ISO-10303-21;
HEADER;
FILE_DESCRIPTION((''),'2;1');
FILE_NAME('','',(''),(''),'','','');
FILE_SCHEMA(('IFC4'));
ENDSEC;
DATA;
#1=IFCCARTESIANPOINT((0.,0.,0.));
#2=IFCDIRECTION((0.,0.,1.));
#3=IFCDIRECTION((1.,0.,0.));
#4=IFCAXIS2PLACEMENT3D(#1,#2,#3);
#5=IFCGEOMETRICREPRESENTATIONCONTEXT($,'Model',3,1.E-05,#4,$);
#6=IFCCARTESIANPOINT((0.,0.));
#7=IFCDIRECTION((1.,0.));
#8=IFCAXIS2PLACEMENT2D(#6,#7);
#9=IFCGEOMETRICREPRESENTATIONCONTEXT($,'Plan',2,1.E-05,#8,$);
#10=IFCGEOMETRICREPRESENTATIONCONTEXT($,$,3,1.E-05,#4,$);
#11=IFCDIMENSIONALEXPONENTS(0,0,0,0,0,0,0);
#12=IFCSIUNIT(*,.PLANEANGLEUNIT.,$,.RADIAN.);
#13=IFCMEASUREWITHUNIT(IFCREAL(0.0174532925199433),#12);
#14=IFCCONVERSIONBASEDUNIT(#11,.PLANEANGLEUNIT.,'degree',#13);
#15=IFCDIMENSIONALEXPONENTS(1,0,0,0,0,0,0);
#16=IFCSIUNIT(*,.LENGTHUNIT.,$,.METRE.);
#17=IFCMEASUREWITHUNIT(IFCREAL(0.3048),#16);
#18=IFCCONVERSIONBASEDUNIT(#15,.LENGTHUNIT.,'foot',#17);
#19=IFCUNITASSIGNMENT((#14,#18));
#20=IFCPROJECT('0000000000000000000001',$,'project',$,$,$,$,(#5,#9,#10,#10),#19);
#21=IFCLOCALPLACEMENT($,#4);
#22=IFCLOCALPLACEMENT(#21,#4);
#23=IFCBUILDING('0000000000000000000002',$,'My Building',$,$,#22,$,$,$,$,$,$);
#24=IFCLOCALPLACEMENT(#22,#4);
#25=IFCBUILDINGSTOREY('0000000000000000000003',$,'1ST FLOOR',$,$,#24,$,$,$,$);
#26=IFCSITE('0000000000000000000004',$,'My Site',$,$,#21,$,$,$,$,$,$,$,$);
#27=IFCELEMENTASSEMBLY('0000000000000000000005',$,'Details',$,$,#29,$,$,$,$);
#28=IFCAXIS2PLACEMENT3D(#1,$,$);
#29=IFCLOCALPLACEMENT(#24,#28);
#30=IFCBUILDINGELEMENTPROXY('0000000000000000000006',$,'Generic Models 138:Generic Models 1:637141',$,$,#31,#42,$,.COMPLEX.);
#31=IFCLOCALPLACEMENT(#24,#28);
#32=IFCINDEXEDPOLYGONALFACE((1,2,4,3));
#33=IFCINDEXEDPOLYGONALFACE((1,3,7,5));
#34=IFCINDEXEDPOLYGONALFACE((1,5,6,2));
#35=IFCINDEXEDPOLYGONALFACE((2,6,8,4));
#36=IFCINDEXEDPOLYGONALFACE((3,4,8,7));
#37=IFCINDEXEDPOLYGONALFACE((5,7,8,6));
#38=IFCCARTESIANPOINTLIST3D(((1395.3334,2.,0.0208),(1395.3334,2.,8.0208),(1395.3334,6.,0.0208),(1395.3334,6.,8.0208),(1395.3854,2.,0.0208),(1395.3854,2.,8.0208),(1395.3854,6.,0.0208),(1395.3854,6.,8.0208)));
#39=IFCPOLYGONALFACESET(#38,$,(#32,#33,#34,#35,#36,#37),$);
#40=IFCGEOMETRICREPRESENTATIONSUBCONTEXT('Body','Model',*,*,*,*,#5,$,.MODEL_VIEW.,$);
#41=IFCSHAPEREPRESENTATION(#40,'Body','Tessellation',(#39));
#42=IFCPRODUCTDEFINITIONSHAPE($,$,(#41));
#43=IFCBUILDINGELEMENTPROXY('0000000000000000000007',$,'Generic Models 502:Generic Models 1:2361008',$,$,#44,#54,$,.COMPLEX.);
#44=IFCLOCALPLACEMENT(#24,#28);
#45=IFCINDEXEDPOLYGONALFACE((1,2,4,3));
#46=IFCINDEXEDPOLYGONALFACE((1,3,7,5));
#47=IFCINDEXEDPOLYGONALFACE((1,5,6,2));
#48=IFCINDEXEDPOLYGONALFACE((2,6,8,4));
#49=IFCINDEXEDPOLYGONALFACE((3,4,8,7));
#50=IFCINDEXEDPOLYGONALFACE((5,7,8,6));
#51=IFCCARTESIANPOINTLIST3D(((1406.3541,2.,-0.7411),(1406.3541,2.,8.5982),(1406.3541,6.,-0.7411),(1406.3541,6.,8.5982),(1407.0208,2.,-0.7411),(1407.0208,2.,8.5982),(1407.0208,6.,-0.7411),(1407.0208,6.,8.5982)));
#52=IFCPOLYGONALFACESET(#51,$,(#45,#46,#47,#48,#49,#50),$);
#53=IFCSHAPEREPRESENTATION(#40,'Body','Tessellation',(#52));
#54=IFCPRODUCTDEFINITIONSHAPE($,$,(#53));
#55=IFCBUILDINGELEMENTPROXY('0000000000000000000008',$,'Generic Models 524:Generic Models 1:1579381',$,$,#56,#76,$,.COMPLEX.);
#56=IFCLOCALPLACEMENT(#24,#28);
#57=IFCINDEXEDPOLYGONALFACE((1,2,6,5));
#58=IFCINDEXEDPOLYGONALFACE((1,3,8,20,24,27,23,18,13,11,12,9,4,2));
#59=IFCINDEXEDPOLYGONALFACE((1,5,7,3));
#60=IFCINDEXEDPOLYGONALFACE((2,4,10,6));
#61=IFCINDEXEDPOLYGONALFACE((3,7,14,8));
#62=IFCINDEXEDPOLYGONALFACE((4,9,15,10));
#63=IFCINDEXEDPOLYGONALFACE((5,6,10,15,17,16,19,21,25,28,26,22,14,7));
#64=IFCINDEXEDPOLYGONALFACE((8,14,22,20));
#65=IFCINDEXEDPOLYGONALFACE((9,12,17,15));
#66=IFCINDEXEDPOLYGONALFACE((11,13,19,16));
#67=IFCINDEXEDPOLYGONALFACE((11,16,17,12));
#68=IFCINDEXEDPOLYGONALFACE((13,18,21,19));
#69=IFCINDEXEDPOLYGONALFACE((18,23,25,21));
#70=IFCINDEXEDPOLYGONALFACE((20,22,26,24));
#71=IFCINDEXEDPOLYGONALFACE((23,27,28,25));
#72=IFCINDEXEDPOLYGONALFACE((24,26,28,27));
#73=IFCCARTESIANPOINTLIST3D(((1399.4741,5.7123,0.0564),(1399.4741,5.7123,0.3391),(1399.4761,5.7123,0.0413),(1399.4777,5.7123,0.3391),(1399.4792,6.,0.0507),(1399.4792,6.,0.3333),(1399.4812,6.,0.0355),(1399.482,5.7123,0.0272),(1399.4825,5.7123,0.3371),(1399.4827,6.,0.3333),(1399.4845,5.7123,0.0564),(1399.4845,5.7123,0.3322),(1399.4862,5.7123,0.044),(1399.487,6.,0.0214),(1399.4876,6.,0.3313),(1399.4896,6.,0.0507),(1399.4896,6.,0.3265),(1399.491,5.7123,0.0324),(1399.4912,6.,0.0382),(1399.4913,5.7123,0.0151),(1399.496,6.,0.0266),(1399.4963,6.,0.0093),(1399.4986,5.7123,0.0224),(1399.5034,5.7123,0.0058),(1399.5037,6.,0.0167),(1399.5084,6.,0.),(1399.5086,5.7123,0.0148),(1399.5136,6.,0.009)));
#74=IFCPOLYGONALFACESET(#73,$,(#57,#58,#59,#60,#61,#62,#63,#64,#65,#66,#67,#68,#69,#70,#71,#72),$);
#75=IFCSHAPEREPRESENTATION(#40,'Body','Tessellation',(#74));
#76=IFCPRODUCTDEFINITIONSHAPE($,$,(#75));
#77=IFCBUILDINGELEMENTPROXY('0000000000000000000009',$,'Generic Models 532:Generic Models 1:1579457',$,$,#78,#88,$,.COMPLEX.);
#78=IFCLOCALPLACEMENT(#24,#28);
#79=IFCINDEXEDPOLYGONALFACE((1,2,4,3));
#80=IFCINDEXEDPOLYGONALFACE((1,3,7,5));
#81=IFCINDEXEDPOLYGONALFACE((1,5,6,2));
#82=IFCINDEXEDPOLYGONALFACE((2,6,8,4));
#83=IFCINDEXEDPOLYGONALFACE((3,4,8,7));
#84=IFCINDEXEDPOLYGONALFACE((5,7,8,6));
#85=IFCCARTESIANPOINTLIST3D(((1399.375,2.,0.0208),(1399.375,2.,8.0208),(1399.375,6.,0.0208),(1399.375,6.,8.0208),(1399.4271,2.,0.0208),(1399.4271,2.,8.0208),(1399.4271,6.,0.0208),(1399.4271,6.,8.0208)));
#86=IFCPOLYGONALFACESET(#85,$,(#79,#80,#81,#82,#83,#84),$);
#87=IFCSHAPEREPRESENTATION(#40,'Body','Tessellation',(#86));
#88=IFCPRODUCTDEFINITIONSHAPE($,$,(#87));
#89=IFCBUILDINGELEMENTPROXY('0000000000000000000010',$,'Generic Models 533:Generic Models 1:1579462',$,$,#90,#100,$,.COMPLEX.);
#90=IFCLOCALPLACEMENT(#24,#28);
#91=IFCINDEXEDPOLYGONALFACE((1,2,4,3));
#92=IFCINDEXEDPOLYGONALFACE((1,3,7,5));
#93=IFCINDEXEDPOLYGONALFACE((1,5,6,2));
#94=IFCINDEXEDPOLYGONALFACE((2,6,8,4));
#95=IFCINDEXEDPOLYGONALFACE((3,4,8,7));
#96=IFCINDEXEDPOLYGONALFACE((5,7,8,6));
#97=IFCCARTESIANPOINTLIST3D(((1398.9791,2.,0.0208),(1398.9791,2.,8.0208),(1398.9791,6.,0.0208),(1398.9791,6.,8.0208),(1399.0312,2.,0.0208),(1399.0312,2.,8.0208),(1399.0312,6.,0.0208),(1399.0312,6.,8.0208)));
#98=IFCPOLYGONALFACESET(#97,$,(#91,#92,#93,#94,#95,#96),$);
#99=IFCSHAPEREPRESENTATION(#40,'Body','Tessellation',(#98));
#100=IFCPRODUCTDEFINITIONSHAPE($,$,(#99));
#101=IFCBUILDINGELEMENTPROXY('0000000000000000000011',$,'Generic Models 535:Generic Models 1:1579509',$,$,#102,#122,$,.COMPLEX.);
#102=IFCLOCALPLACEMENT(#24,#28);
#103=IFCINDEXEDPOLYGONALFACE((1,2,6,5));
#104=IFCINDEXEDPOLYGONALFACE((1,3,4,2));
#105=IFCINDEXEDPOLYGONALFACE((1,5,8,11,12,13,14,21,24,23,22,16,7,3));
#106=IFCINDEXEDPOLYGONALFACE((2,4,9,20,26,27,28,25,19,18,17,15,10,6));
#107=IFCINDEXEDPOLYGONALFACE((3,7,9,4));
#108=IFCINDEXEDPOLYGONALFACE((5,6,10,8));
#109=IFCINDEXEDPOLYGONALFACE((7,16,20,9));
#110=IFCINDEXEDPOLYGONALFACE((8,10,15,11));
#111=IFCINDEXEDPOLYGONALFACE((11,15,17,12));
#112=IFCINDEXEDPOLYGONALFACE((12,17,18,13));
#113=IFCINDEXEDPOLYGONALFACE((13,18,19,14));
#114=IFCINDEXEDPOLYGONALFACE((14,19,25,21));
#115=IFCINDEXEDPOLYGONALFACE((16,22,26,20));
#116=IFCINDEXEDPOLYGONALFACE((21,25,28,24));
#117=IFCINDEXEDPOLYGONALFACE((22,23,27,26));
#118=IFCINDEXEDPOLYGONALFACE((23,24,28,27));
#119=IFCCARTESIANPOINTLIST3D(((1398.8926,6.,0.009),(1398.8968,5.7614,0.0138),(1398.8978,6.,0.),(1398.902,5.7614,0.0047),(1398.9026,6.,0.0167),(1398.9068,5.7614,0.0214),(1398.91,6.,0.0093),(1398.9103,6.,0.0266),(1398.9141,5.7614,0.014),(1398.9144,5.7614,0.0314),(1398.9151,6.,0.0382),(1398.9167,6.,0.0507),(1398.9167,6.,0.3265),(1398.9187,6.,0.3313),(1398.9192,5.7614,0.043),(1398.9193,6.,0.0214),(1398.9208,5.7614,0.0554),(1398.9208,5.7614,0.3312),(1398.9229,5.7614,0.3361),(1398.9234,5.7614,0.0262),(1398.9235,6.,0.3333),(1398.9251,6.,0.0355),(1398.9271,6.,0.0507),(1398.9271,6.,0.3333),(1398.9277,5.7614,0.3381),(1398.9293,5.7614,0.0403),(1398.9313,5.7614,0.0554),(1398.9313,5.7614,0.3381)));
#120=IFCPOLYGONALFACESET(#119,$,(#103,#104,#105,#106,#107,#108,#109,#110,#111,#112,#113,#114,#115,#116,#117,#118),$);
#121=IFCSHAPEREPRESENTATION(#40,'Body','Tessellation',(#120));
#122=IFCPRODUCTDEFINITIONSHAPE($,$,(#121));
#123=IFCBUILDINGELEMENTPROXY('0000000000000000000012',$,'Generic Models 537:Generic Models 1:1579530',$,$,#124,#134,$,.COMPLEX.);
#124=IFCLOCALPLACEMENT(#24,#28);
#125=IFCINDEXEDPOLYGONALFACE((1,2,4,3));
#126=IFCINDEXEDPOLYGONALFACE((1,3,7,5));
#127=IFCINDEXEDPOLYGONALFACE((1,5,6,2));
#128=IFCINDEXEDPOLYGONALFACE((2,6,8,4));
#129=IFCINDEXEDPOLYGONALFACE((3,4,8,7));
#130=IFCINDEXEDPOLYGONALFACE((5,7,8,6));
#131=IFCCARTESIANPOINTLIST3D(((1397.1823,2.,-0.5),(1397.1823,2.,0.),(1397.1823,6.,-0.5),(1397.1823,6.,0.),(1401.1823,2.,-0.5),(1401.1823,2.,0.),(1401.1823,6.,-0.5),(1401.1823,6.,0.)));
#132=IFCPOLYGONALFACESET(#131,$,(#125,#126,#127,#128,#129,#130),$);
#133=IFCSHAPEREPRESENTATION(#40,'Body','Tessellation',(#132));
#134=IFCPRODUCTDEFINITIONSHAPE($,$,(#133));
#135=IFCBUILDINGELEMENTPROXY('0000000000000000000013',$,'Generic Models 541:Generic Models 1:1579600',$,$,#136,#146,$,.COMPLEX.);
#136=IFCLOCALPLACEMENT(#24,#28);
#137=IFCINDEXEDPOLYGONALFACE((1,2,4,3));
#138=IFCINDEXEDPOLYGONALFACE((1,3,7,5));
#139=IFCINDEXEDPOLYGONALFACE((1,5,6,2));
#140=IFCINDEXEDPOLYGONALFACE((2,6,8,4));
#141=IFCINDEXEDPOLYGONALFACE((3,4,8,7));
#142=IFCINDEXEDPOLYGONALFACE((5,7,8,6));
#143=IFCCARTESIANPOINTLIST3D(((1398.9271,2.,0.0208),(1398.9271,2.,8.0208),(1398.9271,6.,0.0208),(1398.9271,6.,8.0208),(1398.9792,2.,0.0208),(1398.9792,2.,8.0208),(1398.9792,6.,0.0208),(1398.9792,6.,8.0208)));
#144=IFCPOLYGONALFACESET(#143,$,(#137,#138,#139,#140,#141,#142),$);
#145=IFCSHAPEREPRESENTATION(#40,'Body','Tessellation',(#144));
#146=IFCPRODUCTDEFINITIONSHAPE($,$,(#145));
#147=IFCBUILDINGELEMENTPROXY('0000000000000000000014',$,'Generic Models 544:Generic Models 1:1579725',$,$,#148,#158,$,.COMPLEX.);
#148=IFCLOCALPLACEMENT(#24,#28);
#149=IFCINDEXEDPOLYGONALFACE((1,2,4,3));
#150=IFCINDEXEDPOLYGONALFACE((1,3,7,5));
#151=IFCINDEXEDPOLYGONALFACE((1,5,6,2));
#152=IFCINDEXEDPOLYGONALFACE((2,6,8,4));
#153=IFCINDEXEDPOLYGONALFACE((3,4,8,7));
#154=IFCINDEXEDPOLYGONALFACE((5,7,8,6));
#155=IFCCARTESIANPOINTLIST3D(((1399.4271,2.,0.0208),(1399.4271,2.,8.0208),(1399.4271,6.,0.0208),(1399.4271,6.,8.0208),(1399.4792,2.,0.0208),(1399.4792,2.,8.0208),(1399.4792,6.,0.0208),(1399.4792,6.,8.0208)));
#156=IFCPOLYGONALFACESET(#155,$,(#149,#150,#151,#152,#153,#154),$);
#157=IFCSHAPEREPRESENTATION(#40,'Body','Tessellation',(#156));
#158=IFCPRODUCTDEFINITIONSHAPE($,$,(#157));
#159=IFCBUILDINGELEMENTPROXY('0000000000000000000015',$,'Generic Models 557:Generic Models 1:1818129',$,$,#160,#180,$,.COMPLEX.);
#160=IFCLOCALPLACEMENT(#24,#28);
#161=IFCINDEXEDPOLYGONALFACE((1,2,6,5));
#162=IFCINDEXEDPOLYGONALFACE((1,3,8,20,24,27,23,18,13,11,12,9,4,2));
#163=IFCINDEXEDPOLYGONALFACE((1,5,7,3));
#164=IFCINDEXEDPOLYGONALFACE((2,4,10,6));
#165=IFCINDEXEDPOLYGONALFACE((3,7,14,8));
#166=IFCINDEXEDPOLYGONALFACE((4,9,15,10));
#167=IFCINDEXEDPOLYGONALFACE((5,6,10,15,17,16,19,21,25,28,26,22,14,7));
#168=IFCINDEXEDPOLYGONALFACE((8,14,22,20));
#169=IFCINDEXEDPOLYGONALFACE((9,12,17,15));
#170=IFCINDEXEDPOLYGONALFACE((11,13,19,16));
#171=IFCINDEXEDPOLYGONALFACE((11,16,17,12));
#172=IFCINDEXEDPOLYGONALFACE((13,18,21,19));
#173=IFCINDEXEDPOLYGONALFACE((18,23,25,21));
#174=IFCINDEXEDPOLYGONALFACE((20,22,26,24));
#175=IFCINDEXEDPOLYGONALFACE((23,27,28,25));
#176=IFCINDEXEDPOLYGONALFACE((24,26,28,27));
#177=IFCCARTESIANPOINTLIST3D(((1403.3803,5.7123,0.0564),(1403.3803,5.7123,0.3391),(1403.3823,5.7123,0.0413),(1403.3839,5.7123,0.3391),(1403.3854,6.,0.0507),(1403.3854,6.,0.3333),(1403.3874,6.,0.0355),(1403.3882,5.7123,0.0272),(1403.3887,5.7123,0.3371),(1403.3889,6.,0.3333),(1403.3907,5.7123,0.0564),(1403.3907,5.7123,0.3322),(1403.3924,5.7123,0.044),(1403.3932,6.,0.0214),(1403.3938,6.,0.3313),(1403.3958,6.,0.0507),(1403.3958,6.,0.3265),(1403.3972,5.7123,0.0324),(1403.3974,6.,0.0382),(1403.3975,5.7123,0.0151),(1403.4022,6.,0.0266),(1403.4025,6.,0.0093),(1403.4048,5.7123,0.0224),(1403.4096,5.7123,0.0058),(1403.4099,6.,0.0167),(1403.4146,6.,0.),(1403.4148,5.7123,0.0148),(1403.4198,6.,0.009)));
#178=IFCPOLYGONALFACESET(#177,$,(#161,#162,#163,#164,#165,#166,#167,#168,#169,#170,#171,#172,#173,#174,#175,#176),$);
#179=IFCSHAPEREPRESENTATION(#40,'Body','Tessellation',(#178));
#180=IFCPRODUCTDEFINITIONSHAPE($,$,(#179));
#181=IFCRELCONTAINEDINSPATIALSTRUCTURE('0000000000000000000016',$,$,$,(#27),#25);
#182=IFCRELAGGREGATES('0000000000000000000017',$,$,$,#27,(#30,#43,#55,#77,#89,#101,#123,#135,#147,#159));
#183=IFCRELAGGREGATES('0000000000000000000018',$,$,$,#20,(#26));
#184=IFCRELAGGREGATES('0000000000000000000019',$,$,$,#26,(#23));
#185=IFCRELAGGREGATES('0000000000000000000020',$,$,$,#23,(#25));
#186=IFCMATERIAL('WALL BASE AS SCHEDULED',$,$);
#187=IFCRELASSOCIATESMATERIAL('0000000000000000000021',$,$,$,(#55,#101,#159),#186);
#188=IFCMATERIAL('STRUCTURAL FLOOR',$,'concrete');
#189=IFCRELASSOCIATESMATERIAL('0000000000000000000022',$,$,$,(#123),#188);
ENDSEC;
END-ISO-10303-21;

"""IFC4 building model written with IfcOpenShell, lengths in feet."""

from ifc_helpers import new_model, entity, si_unit, converted_unit, frame, origin_with_axes, origin_2d_with_axis, place, context, subcontext, project, spatial, polyline, line, indexed_curve, outline, extrude, material, element, aggregate, save


model = new_model("IFC4")

# Units and contexts
model_context = context("Model", 3, precision=1e-05, world=origin_with_axes())
plan_context = context("Plan", 2, precision=1e-05, world=origin_2d_with_axis())
context_of_model = context(None, 3, precision=1e-05, world=origin_with_axes())
body_context = subcontext(model_context, "Body", "Model", "MODEL_VIEW")
ifc_project = project(units=[converted_unit("PLANEANGLEUNIT", "degree", entity("IfcReal", 0.0174532925199433), si_unit("PLANEANGLEUNIT", "RADIAN"), dimensions=[0, 0, 0, 0, 0, 0, 0]), converted_unit("LENGTHUNIT", "foot", entity("IfcReal", 0.3048), si_unit("LENGTHUNIT", "METRE"), dimensions=[1, 0, 0, 0, 0, 0, 0])], contexts=[model_context, plan_context, context_of_model, context_of_model])

# Site, building, storey
site_placement = place(None, origin_with_axes())
site = spatial("IfcSite", under=ifc_project, at=site_placement, Name="My Site")
building_placement = place(site_placement, origin_with_axes())
building = spatial("IfcBuilding", under=site, at=building_placement, Name="My Building")
storey_placement = place(building_placement, origin_with_axes())
storey = spatial("IfcBuildingStorey", under=building, at=storey_placement, Name="1ST FLOOR")

# Element assembly, building element proxies
assembly_placement = place(storey_placement, origin_with_axes())
assembly = element("IfcElementAssembly", 1, at=assembly_placement, inside=storey, Name="Details")
proxy_1_placement = place(assembly_placement, frame((1395.3334, 6.0, 0.0208), z_axis=(0.0, -1.0, 0.0), x_axis=(0.0, 0.0, 1.0)))
proxy_1 = element("IfcBuildingElementProxy", 2, at=proxy_1_placement, Name="Generic Models 138:Generic Models 1:637141", PredefinedType="COMPLEX", context=body_context, shape_type="SweptSolid", body=[
    extrude(outline(indexed_curve([(-0.026, -4.0), (0.026, -4.0), (0.026, 4.0), (-0.026, 4.0)], segments=[line(4, 1), line(1, 2), line(2, 3), line(3, 4)], self_intersect=False)), frame((4.0, -0.026, 0.0), z_axis=(0.0, 0.0, -1.0), x_axis=(0.0, 1.0, 0.0)), (0.0, 0.0, -1.0), 4.0),
])
proxy_2_placement = place(assembly_placement, frame((1406.3541, 6.0, -0.7411), z_axis=(0.0, -1.0, 0.0), x_axis=(0.0, 0.0, 1.0)))
proxy_2 = element("IfcBuildingElementProxy", 3, at=proxy_2_placement, Name="Generic Models 502:Generic Models 1:2361008", PredefinedType="COMPLEX", context=body_context, shape_type="SweptSolid", body=[
    extrude(outline(indexed_curve([(-0.3333, -4.6697), (0.3333, -4.6697), (0.3333, 4.6697), (-0.3333, 4.6697)], segments=[line(4, 1), line(1, 2), line(2, 3), line(3, 4)], self_intersect=False)), frame((4.6697, -0.3333, 0.0), z_axis=(0.0, 0.0, -1.0), x_axis=(0.0, 1.0, 0.0)), (0.0, 0.0, -1.0), 4.0),
])
ifc_material_1 = material(Name="WALL BASE AS SCHEDULED")
proxy_3_placement = place(assembly_placement, frame((1399.4792, 6.0, 0.0), z_axis=(0.0, -1.0, 0.0), x_axis=(0.0, 0.0, 1.0)))
proxy_3 = element("IfcBuildingElementProxy", 4, at=proxy_3_placement, material=ifc_material_1, Name="Generic Models 524:Generic Models 1:1579381", PredefinedType="COMPLEX", context=body_context, shape_type="SweptSolid", body=[
    extrude(outline(polyline([(0.0865, 0.0), (0.0968, -0.0072), (0.105, -0.0167), (0.1137, -0.0111), (0.1038, 0.0006), (0.0913, 0.0093), (0.0769, 0.0144), (0.0617, 0.0157), (-0.2206, 0.0019), (-0.2205, -0.0017), (-0.2182, -0.0064), (-0.2133, -0.0082), (0.0622, 0.0053), (0.0747, 0.0042), (0.0865, 0.0)])), frame((0.113, -0.0126, 0.0), z_axis=(0.0, 0.0, -1.0), x_axis=(-0.998808, -0.048806, 0.0)), (-0.020832, 0.016543, -0.999646), 0.2878),
])
proxy_4_placement = place(assembly_placement, frame((1399.375, 6.0, 0.0208), z_axis=(0.0, -1.0, 0.0), x_axis=(0.0, 0.0, 1.0)))
proxy_4 = element("IfcBuildingElementProxy", 5, at=proxy_4_placement, Name="Generic Models 532:Generic Models 1:1579457", PredefinedType="COMPLEX", context=body_context, shape_type="SweptSolid", body=[
    extrude(outline(polyline([(-4.0, -0.026), (4.0, -0.026), (4.0, 0.026), (-4.0, 0.026), (-4.0, -0.026)])), frame((4.0, -0.026, 0.0), z_axis=(0.0, 0.0, -1.0), x_axis=(1.0, 0.0, 0.0)), (0.0, 0.0, -1.0), 4.0),
])
proxy_5_placement = place(assembly_placement, frame((1398.9791, 6.0, 0.0208), z_axis=(0.0, -1.0, 0.0), x_axis=(0.0, 0.0, 1.0)))
proxy_5 = element("IfcBuildingElementProxy", 6, at=proxy_5_placement, Name="Generic Models 533:Generic Models 1:1579462", PredefinedType="COMPLEX", context=body_context, shape_type="SweptSolid", body=[
    extrude(outline(polyline([(-0.026, -4.0), (0.026, -4.0), (0.026, 4.0), (-0.026, 4.0), (-0.026, -4.0)])), frame((4.0, -0.026, 0.0), z_axis=(0.0, 0.0, -1.0), x_axis=(0.0, -1.0, 0.0)), (0.0, 0.0, -1.0), 4.0),
])
proxy_6_placement = place(assembly_placement, frame((1398.8926, 6.0, 0.0), z_axis=(0.0, -1.0, 0.0), x_axis=(0.0, 0.0, 1.0)))
proxy_6 = element("IfcBuildingElementProxy", 7, at=proxy_6_placement, material=ifc_material_1, Name="Generic Models 535:Generic Models 1:1579509", PredefinedType="COMPLEX", context=body_context, shape_type="SweptSolid", body=[
    extrude(outline(polyline([(-0.2203, -0.0126), (0.0624, -0.0126), (0.0775, -0.0106), (0.0916, -0.0048), (0.1037, 0.0045), (0.113, 0.0166), (0.104, 0.0218), (0.0964, 0.0119), (0.0864, 0.0042), (0.0748, -0.0006), (0.0624, -0.0022), (-0.2134, -0.0022), (-0.2183, -0.0042), (-0.2203, -0.0091), (-0.2203, -0.0126)])), frame((0.113, -0.0218, 0.0), z_axis=(0.0, 0.0, -1.0), x_axis=(-1.0, 0.0, 0.0)), (-0.01982, -0.017382, -0.999652), 0.2387),
])
ifc_material_2 = material(Name="STRUCTURAL FLOOR", Category="concrete")
proxy_7_placement = place(assembly_placement, frame((1397.1823, 6.0, -0.5), z_axis=(0.0, -1.0, 0.0), x_axis=(0.0, 0.0, 1.0)))
proxy_7 = element("IfcBuildingElementProxy", 8, at=proxy_7_placement, material=ifc_material_2, Name="Generic Models 537:Generic Models 1:1579530", PredefinedType="COMPLEX", context=body_context, shape_type="SweptSolid", body=[
    extrude(outline(polyline([(-0.25, -2.0), (0.25, -2.0), (0.25, 2.0), (-0.25, 2.0), (-0.25, -2.0)])), frame((0.25, -2.0, 0.0), z_axis=(0.0, 0.0, -1.0), x_axis=(1.0, 0.0, 0.0)), (0.0, 0.0, -1.0), 4.0),
])
proxy_8_placement = place(assembly_placement, frame((1398.9271, 6.0, 0.0208), z_axis=(0.0, -1.0, 0.0), x_axis=(0.0, 0.0, 1.0)))
proxy_8 = element("IfcBuildingElementProxy", 9, at=proxy_8_placement, Name="Generic Models 541:Generic Models 1:1579600", PredefinedType="COMPLEX", context=body_context, shape_type="SweptSolid", body=[
    extrude(outline(polyline([(-4.0, -0.026), (4.0, -0.026), (4.0, 0.026), (-4.0, 0.026), (-4.0, -0.026)])), frame((4.0, -0.026, 0.0), z_axis=(0.0, 0.0, -1.0), x_axis=(1.0, 0.0, 0.0)), (0.0, 0.0, -1.0), 4.0),
])
proxy_9_placement = place(assembly_placement, frame((1399.4271, 6.0, 0.0208), z_axis=(0.0, -1.0, 0.0), x_axis=(0.0, 0.0, 1.0)))
proxy_9 = element("IfcBuildingElementProxy", 10, at=proxy_9_placement, Name="Generic Models 544:Generic Models 1:1579725", PredefinedType="COMPLEX", context=body_context, shape_type="SweptSolid", body=[
    extrude(outline(indexed_curve([(-4.0, -0.026), (4.0, -0.026), (4.0, 0.026), (-4.0, 0.026)], segments=[line(3, 2), line(2, 1), line(1, 4), line(4, 3)], self_intersect=False)), frame((4.0, -0.026, 0.0), z_axis=(0.0, 0.0, -1.0), x_axis=(1.0, 0.0, 0.0)), (0.0, 0.0, -1.0), 4.0),
])
proxy_10_placement = place(assembly_placement, frame((1403.3854, 6.0, 0.0), z_axis=(0.0, -1.0, 0.0), x_axis=(0.0, 0.0, 1.0)))
proxy_10 = element("IfcBuildingElementProxy", 11, at=proxy_10_placement, material=ifc_material_1, Name="Generic Models 557:Generic Models 1:1818129", PredefinedType="COMPLEX", context=body_context, shape_type="SweptSolid", body=[
    extrude(outline(polyline([(0.1038, 0.0), (0.0913, 0.0088), (0.077, 0.014), (0.0618, 0.0153), (-0.2206, 0.0031), (-0.2205, -0.0005), (-0.2183, -0.0052), (-0.2133, -0.007), (0.0622, 0.0049), (0.0747, 0.0038), (0.0865, -0.0005), (0.0968, -0.0077), (0.1049, -0.0173), (0.1137, -0.0117), (0.1038, 0.0)])), frame((0.113, -0.0126, 0.0), z_axis=(0.0, 0.0, -1.0), x_axis=(-0.999059, -0.043362, 0.0)), (-0.020742, 0.016656, -0.999646), 0.2878),
])
aggregate(assembly, [proxy_1, proxy_2, proxy_3, proxy_4, proxy_5, proxy_6, proxy_7, proxy_8, proxy_9, proxy_10])

save(model, "model.ifc")
